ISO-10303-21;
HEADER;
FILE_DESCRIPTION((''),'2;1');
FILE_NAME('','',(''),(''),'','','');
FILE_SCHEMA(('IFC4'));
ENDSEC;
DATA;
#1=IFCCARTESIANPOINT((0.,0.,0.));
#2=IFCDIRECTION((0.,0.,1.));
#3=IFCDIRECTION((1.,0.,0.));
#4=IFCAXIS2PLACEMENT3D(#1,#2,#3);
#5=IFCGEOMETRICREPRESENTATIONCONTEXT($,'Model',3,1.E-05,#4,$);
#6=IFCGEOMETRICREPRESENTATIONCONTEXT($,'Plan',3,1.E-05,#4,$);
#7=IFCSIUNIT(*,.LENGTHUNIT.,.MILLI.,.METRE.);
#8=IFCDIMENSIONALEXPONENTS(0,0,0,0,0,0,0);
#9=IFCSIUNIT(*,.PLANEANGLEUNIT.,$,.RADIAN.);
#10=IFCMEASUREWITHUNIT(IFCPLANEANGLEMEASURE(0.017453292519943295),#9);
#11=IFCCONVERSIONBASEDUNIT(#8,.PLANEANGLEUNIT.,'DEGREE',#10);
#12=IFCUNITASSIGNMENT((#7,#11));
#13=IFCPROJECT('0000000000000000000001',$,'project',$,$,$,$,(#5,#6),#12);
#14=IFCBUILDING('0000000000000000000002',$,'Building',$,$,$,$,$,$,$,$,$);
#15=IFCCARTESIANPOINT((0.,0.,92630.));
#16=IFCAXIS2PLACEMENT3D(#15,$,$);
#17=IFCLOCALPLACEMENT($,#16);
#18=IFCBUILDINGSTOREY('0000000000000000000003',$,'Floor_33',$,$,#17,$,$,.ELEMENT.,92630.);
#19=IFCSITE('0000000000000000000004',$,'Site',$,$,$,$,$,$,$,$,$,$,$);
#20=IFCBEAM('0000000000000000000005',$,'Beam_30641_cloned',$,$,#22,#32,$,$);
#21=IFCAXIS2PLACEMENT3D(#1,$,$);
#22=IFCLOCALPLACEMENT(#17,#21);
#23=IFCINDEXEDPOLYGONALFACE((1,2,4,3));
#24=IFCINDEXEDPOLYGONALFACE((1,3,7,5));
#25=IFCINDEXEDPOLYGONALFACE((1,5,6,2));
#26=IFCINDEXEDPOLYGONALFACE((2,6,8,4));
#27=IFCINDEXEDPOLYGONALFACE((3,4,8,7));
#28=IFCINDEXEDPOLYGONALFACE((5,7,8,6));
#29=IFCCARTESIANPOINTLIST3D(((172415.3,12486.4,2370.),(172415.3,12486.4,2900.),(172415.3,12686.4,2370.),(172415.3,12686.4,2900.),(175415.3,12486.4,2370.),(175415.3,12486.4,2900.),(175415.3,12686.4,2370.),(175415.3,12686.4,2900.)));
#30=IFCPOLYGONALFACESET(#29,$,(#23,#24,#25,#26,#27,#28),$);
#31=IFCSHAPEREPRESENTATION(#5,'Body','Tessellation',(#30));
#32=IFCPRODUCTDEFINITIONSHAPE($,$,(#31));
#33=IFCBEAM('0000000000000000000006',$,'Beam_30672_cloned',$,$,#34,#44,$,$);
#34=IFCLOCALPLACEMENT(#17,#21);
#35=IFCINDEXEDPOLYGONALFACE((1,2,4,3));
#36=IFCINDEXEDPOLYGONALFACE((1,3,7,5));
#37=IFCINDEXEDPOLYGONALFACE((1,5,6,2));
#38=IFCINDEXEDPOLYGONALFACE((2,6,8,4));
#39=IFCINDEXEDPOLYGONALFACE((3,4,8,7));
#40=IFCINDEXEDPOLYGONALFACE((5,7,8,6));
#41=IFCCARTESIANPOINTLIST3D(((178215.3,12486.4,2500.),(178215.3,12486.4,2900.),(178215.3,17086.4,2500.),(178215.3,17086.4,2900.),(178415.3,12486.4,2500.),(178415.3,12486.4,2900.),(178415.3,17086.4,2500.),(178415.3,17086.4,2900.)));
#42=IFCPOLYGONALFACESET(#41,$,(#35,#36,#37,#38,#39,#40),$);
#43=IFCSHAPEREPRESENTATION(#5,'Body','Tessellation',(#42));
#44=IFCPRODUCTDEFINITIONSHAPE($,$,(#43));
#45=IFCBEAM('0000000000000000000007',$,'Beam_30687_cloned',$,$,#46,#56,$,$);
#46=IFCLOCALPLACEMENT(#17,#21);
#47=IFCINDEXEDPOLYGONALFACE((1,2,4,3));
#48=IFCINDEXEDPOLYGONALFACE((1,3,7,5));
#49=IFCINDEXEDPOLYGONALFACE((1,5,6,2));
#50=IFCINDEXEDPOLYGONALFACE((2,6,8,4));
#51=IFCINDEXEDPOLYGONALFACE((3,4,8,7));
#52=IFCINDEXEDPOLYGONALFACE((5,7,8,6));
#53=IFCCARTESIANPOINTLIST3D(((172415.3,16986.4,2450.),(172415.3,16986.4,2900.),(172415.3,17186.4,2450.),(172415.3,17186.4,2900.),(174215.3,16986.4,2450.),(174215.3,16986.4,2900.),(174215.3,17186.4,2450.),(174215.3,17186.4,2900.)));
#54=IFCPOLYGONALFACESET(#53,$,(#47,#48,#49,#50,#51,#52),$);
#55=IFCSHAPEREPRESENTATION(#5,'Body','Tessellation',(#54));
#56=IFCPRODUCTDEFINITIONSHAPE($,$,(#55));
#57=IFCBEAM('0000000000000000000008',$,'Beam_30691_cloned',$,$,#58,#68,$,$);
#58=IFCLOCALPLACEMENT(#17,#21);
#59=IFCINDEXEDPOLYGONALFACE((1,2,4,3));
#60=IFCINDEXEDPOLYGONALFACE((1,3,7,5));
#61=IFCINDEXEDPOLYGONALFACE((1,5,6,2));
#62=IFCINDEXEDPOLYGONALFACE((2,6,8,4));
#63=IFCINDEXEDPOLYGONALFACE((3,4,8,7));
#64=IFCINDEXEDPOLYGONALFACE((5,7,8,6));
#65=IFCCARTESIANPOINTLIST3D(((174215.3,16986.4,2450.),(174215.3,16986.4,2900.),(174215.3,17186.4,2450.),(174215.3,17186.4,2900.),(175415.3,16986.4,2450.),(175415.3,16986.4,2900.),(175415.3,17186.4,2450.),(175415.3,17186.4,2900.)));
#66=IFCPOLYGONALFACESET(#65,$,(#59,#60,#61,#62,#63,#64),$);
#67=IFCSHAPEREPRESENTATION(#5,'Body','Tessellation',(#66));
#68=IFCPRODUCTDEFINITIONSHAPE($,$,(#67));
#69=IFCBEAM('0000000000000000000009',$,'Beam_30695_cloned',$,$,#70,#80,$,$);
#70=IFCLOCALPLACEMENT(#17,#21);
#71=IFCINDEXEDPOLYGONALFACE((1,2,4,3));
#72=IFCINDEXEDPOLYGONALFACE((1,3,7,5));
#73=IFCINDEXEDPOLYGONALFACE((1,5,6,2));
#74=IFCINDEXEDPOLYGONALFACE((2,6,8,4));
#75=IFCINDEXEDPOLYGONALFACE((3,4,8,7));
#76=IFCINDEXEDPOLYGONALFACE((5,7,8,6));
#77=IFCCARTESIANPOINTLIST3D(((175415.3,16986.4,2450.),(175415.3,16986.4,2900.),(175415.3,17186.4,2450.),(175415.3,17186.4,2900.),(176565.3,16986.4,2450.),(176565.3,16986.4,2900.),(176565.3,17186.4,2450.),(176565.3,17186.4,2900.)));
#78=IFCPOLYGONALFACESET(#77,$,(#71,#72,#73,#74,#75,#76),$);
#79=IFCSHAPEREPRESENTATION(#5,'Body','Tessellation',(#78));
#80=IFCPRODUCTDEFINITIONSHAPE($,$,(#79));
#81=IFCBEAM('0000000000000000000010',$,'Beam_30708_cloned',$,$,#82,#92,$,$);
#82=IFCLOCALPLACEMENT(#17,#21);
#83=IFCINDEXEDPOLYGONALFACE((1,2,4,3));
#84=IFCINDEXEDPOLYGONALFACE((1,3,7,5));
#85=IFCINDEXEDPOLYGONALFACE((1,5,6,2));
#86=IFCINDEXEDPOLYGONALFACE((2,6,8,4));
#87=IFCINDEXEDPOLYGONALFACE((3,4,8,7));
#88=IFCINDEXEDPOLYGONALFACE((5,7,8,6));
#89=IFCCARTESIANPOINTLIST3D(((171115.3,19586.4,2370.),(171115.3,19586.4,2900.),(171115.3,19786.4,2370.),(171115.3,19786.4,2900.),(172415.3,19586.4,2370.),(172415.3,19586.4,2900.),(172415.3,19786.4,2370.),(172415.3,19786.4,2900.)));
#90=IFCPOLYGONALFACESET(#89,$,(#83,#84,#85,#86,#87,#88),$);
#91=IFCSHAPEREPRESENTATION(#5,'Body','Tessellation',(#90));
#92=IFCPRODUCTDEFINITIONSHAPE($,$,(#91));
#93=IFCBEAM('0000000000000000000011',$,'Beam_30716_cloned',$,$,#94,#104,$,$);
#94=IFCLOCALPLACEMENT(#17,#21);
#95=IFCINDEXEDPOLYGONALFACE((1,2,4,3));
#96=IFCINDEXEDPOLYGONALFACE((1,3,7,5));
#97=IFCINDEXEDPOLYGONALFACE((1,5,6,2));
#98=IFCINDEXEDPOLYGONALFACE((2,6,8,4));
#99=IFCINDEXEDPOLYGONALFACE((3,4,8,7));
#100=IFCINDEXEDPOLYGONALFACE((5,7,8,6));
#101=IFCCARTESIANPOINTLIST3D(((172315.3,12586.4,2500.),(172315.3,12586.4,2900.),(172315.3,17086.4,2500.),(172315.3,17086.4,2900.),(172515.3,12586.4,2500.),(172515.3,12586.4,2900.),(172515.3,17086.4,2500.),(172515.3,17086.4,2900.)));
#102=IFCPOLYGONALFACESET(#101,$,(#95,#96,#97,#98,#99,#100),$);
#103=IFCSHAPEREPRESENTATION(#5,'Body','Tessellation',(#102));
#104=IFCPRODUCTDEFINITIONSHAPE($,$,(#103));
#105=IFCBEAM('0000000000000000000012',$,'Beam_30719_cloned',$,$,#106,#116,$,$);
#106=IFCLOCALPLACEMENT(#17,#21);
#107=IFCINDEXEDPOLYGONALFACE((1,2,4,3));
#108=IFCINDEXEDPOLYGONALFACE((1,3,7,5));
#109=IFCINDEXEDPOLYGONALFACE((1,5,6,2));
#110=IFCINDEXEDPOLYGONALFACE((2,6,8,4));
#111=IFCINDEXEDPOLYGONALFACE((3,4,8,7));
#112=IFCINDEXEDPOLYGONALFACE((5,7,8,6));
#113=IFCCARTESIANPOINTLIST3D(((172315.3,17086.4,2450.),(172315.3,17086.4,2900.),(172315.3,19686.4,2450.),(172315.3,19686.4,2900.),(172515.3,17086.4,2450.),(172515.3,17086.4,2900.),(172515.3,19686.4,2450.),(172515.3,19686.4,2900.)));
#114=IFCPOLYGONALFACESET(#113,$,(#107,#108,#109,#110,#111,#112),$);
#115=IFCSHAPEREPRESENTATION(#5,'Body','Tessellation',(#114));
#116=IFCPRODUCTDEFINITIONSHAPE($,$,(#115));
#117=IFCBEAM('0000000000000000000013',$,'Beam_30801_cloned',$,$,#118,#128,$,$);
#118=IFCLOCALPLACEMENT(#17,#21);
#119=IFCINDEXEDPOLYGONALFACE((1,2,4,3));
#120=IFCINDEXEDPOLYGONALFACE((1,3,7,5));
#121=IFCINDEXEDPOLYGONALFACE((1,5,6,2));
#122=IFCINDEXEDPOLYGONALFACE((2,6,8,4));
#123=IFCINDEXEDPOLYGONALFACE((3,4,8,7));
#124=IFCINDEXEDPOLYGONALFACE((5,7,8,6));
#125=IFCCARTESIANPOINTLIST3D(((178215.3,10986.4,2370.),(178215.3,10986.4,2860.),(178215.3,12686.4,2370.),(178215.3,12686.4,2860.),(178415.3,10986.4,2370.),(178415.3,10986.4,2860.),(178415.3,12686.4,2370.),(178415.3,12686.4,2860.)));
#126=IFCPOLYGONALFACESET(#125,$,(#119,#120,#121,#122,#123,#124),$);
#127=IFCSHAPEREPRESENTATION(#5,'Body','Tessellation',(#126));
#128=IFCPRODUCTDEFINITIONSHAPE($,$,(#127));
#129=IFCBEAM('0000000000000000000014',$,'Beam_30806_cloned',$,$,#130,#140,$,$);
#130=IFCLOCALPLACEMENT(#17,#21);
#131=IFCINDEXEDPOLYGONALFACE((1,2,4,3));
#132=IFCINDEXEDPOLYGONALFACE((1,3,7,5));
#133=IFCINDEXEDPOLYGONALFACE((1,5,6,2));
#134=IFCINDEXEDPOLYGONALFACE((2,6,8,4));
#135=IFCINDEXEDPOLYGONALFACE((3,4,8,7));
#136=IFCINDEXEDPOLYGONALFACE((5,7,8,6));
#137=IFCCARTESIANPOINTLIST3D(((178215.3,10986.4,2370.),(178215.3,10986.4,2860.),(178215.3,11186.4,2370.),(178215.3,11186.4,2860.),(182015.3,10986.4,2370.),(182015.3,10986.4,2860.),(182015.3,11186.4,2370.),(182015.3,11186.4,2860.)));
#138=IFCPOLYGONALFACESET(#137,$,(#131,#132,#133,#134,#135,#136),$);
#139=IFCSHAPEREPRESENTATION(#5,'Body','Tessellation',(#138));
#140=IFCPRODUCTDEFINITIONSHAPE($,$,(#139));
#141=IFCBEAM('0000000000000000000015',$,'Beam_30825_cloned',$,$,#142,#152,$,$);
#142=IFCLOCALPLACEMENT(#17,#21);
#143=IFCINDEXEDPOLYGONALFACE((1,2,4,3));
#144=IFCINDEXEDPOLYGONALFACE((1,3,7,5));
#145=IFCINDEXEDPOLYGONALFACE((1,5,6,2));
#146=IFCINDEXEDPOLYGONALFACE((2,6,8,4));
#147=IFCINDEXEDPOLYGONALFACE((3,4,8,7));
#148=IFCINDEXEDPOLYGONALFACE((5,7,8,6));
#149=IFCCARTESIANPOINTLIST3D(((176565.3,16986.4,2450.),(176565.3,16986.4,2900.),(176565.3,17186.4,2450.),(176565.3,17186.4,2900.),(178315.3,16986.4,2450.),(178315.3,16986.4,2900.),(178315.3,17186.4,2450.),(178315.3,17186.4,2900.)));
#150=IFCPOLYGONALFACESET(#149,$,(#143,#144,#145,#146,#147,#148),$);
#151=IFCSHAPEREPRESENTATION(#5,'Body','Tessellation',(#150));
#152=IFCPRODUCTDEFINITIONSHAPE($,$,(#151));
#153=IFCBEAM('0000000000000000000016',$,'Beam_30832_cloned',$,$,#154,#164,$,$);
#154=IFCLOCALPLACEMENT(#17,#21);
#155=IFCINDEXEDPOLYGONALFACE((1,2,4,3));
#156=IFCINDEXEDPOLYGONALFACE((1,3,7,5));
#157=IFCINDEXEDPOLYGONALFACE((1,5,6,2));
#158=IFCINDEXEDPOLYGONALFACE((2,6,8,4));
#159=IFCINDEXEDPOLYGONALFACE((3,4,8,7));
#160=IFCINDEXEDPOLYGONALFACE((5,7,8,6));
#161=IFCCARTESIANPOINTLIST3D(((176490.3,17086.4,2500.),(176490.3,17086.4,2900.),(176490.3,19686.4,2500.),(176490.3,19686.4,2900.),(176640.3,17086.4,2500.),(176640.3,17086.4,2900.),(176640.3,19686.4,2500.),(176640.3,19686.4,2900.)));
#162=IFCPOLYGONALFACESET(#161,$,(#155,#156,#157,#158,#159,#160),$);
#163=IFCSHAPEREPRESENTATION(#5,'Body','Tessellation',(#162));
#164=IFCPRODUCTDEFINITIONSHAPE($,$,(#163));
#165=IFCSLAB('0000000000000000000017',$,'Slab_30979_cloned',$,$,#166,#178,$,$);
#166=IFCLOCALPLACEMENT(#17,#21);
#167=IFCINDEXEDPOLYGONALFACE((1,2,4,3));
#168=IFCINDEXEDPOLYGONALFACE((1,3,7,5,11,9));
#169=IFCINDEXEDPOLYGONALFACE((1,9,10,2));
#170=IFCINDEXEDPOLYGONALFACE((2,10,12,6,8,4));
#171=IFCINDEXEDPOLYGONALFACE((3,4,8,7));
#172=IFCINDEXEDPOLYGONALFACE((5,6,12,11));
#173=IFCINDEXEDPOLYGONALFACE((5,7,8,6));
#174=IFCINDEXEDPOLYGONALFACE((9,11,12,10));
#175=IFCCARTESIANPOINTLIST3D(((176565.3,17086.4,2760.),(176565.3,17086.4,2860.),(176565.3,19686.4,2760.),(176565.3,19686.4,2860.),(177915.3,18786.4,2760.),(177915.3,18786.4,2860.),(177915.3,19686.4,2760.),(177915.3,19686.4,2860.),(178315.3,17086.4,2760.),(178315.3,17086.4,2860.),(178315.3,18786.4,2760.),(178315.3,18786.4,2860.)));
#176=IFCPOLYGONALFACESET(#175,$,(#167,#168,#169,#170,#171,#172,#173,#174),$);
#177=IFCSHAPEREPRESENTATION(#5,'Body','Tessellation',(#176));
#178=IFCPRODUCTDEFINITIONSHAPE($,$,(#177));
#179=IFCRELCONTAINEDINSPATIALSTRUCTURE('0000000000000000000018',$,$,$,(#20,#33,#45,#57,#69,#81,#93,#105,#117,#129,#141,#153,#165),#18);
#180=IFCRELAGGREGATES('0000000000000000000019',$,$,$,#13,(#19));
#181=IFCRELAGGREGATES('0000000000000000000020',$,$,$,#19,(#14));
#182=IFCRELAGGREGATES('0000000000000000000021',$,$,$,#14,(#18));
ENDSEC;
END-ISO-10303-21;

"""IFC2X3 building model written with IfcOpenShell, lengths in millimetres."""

from ifc_helpers import new_model, entity, si_unit, converted_unit, frame, origin_with_axes, origin_2d, place, context, project, spatial, polyline, rectangle, outline, extrude, source, transform, mapped, element, save


model = new_model("IFC2X3")

# Units and contexts
model_context = context("Model", 3, precision=1e-05, world=origin_with_axes())
plan_context = context("Plan", 3, precision=1e-05, world=origin_with_axes())
ifc_project = project(units=[si_unit("LENGTHUNIT", "METRE", prefix="MILLI"), converted_unit("PLANEANGLEUNIT", "DEGREE", entity("IfcPlaneAngleMeasure", 0.017453292519943295), si_unit("PLANEANGLEUNIT", "RADIAN"), dimensions=[0, 0, 0, 0, 0, 0, 0])], contexts=[model_context, plan_context])

# Site, building, storey
site = spatial("IfcSite", under=ifc_project, Name="Site")
building = spatial("IfcBuilding", under=site, Name="Building")
storey_placement = place(None, frame((0.0, 0.0, 92630.0)))
storey = spatial("IfcBuildingStorey", under=building, at=storey_placement, Name="Floor_33", CompositionType="ELEMENT", Elevation=92630.0)

# Beams
shared_shape_1 = source(origin_with_axes(), model_context, "Body", "SweptSolid", [
    extrude(rectangle(XDim=200.0, YDim=530.0, at=origin_2d()), origin_with_axes(), (0.0, 0.0, 1.0), 3000.0),
])
beam_1_placement = place(storey_placement, frame((172415.3, 12586.4, 2635.0), z_axis=(2999.999693, 0.0, 0.0), x_axis=(0.0, -2999.999693, 0.0)))
element("IfcBeam", 1, at=beam_1_placement, inside=storey, Name="Beam_30641_cloned", context=model_context, shape_type="MappedRepresentation", body=[
    mapped(shared_shape_1, transform((0.0, 0.0, 0.0), x_axis=(1.0, 0.0, 0.0), y_axis=(0.0, 1.0, 0.0), z_axis=(0.0, 0.0, 1.0), scale=1.0)),
])
shared_shape_2 = source(origin_with_axes(), model_context, "Body", "SweptSolid", [
    extrude(rectangle(XDim=200.0, YDim=400.0, at=origin_2d()), origin_with_axes(), (0.0, 0.0, 1.0), 4600.0),
])
beam_2_placement = place(storey_placement, frame((178315.3, 12486.4, 2700.0), z_axis=(-0.000341, 4600.030689, 0.0), x_axis=(4600.030689, 0.000341, 0.0)))
element("IfcBeam", 2, at=beam_2_placement, inside=storey, Name="Beam_30672_cloned", context=model_context, shape_type="MappedRepresentation", body=[
    mapped(shared_shape_2, transform((0.0, 0.0, 0.0), x_axis=(1.0, 0.0, 0.0), y_axis=(0.0, 1.0, 0.0), z_axis=(0.0, 0.0, 1.0), scale=1.0)),
])
shared_shape_3 = source(origin_with_axes(), model_context, "Body", "SweptSolid", [
    extrude(rectangle(XDim=200.0, YDim=450.0, at=origin_2d()), origin_with_axes(), (0.0, 0.0, 1.0), 1800.0),
])
beam_3_placement = place(storey_placement, frame((172415.3, 17086.4, 2675.0), z_axis=(1800.000018, -0.000024, 0.0), x_axis=(-0.000024, -1800.000018, 0.0)))
element("IfcBeam", 3, at=beam_3_placement, inside=storey, Name="Beam_30687_cloned", context=model_context, shape_type="MappedRepresentation", body=[
    mapped(shared_shape_3, transform((0.0, 0.0, 0.0), x_axis=(1.0, 0.0, 0.0), y_axis=(0.0, 1.0, 0.0), z_axis=(0.0, 0.0, 1.0), scale=1.0)),
])
shared_shape_4 = source(origin_with_axes(), model_context, "Body", "SweptSolid", [
    extrude(rectangle(XDim=200.0, YDim=450.0, at=origin_2d()), origin_with_axes(), (0.0, 0.0, 1.0), 1200.0),
])
beam_4_placement = place(storey_placement, frame((174215.3, 17086.4, 2675.0), z_axis=(1199.999669, 0.000037, 0.0), x_axis=(0.000037, -1199.999669, 0.0)))
element("IfcBeam", 4, at=beam_4_placement, inside=storey, Name="Beam_30691_cloned", context=model_context, shape_type="MappedRepresentation", body=[
    mapped(shared_shape_4, transform((0.0, 0.0, 0.0), x_axis=(1.0, 0.0, 0.0), y_axis=(0.0, 1.0, 0.0), z_axis=(0.0, 0.0, 1.0), scale=1.0)),
])
shared_shape_5 = source(origin_with_axes(), model_context, "Body", "SweptSolid", [
    extrude(rectangle(XDim=200.0, YDim=450.0, at=origin_2d()), origin_with_axes(), (0.0, 0.0, 1.0), 1150.0),
])
beam_5_placement = place(storey_placement, frame((175415.3, 17086.4, 2675.0), z_axis=(1149.999861, 0.000005, 0.0), x_axis=(0.000005, -1149.999861, 0.0)))
element("IfcBeam", 5, at=beam_5_placement, inside=storey, Name="Beam_30695_cloned", context=model_context, shape_type="MappedRepresentation", body=[
    mapped(shared_shape_5, transform((0.0, 0.0, 0.0), x_axis=(1.0, 0.0, 0.0), y_axis=(0.0, 1.0, 0.0), z_axis=(0.0, 0.0, 1.0), scale=1.0)),
])
shared_shape_6 = source(origin_with_axes(), model_context, "Body", "SweptSolid", [
    extrude(rectangle(XDim=200.0, YDim=530.0, at=origin_2d()), origin_with_axes(), (0.0, 0.0, 1.0), 1300.0),
])
beam_6_placement = place(storey_placement, frame((171115.3, 19686.4, 2635.0), z_axis=(1300.000018, 0.0, 0.0), x_axis=(0.0, -1300.000018, 0.0)))
element("IfcBeam", 6, at=beam_6_placement, inside=storey, Name="Beam_30708_cloned", context=model_context, shape_type="MappedRepresentation", body=[
    mapped(shared_shape_6, transform((0.0, 0.0, 0.0), x_axis=(1.0, 0.0, 0.0), y_axis=(0.0, 1.0, 0.0), z_axis=(0.0, 0.0, 1.0), scale=1.0)),
])
shared_shape_7 = source(origin_with_axes(), model_context, "Body", "SweptSolid", [
    extrude(rectangle(XDim=200.0, YDim=400.0, at=origin_2d()), origin_with_axes(), (0.0, 0.0, 1.0), 4500.0),
])
beam_7_placement = place(storey_placement, frame((172415.3, 12586.4, 2700.0), z_axis=(0.0, 4500.030665, 0.0), x_axis=(4500.030665, 0.0, 0.0)))
element("IfcBeam", 7, at=beam_7_placement, inside=storey, Name="Beam_30716_cloned", context=model_context, shape_type="MappedRepresentation", body=[
    mapped(shared_shape_7, transform((0.0, 0.0, 0.0), x_axis=(1.0, 0.0, 0.0), y_axis=(0.0, 1.0, 0.0), z_axis=(0.0, 0.0, 1.0), scale=1.0)),
])
shared_shape_8 = source(origin_with_axes(), model_context, "Body", "SweptSolid", [
    extrude(rectangle(XDim=200.0, YDim=450.0, at=origin_2d()), origin_with_axes(), (0.0, 0.0, 1.0), 2600.0),
])
beam_8_placement = place(storey_placement, frame((172415.3, 17086.4, 2675.0), z_axis=(0.0, 2599.990188, 0.0), x_axis=(2599.990188, 0.0, 0.0)))
element("IfcBeam", 8, at=beam_8_placement, inside=storey, Name="Beam_30719_cloned", context=model_context, shape_type="MappedRepresentation", body=[
    mapped(shared_shape_8, transform((0.0, 0.0, 0.0), x_axis=(1.0, 0.0, 0.0), y_axis=(0.0, 1.0, 0.0), z_axis=(0.0, 0.0, 1.0), scale=1.0)),
])
shared_shape_9 = source(origin_with_axes(), model_context, "Body", "SweptSolid", [
    extrude(rectangle(XDim=200.0, YDim=490.0, at=origin_2d()), origin_with_axes(), (0.0, 0.0, 1.0), 1700.0),
])
beam_9_placement = place(storey_placement, frame((178315.3, 10986.4, 2615.0), z_axis=(0.0, 1700.0, 0.0), x_axis=(1700.0, 0.0, 0.0)))
element("IfcBeam", 9, at=beam_9_placement, inside=storey, Name="Beam_30801_cloned", context=model_context, shape_type="MappedRepresentation", body=[
    mapped(shared_shape_9, transform((0.0, 0.0, 0.0), x_axis=(1.0, 0.0, 0.0), y_axis=(0.0, 1.0, 0.0), z_axis=(0.0, 0.0, 1.0), scale=1.0)),
])
shared_shape_10 = source(origin_with_axes(), model_context, "Body", "SweptSolid", [
    extrude(rectangle(XDim=200.0, YDim=490.0, at=origin_2d()), origin_with_axes(), (0.0, 0.0, 1.0), 3800.0),
])
beam_10_placement = place(storey_placement, frame((178215.3, 11086.4, 2615.0), z_axis=(3800.00001, 0.0, 0.0), x_axis=(0.0, -3800.00001, 0.0)))
element("IfcBeam", 10, at=beam_10_placement, inside=storey, Name="Beam_30806_cloned", context=model_context, shape_type="MappedRepresentation", body=[
    mapped(shared_shape_10, transform((0.0, 0.0, 0.0), x_axis=(1.0, 0.0, 0.0), y_axis=(0.0, 1.0, 0.0), z_axis=(0.0, 0.0, 1.0), scale=1.0)),
])
shared_shape_11 = source(origin_with_axes(), model_context, "Body", "SweptSolid", [
    extrude(rectangle(XDim=200.0, YDim=450.0, at=origin_2d()), origin_with_axes(), (0.0, 0.0, 1.0), 1750.0),
])
beam_11_placement = place(storey_placement, frame((176565.3, 17086.4, 2675.0), z_axis=(1750.0, 0.000007, 0.0), x_axis=(0.000007, -1750.0, 0.0)))
element("IfcBeam", 11, at=beam_11_placement, inside=storey, Name="Beam_30825_cloned", context=model_context, shape_type="MappedRepresentation", body=[
    mapped(shared_shape_11, transform((0.0, 0.0, 0.0), x_axis=(1.0, 0.0, 0.0), y_axis=(0.0, 1.0, 0.0), z_axis=(0.0, 0.0, 1.0), scale=1.0)),
])
shared_shape_12 = source(origin_with_axes(), model_context, "Body", "SweptSolid", [
    extrude(rectangle(XDim=150.0, YDim=400.0, at=origin_2d()), origin_with_axes(), (0.0, 0.0, 1.0), 2600.0),
])
beam_12_placement = place(storey_placement, frame((176565.3, 17086.4, 2700.0), z_axis=(0.0, 2599.990171, 0.0), x_axis=(2599.990171, 0.0, 0.0)))
element("IfcBeam", 12, at=beam_12_placement, inside=storey, Name="Beam_30832_cloned", context=model_context, shape_type="MappedRepresentation", body=[
    mapped(shared_shape_12, transform((0.0, 0.0, 0.0), x_axis=(1.0, 0.0, 0.0), y_axis=(0.0, 1.0, 0.0), z_axis=(0.0, 0.0, 1.0), scale=1.0)),
])

# Slab
shared_shape_13 = source(origin_with_axes(), model_context, "Body", "SweptSolid", [
    extrude(outline(polyline([(0.0, 0.0), (1350.0, 0.0), (1350.0, 2600.0), (-400.0, 2600.0), (-400.0, 900.0), (0.0, 900.0)])), origin_with_axes(), (0.0, 0.0, 1.0), 100.0),
])
slab_1_placement = place(storey_placement, frame((177915.3, 19686.4, 2760.0), z_axis=(0.0, 0.0, 1.0), x_axis=(-1350.0, 0.0, 0.0)))
element("IfcSlab", 13, at=slab_1_placement, inside=storey, Name="Slab_30979_cloned", context=model_context, shape_type="MappedRepresentation", body=[
    mapped(shared_shape_13, transform((0.0, 0.0, 0.0), x_axis=(1.0, 0.0, 0.0), y_axis=(0.0, 1.0, 0.0), z_axis=(0.0, 0.0, 1.0), scale=1.0)),
])

save(model, "model.ifc")
